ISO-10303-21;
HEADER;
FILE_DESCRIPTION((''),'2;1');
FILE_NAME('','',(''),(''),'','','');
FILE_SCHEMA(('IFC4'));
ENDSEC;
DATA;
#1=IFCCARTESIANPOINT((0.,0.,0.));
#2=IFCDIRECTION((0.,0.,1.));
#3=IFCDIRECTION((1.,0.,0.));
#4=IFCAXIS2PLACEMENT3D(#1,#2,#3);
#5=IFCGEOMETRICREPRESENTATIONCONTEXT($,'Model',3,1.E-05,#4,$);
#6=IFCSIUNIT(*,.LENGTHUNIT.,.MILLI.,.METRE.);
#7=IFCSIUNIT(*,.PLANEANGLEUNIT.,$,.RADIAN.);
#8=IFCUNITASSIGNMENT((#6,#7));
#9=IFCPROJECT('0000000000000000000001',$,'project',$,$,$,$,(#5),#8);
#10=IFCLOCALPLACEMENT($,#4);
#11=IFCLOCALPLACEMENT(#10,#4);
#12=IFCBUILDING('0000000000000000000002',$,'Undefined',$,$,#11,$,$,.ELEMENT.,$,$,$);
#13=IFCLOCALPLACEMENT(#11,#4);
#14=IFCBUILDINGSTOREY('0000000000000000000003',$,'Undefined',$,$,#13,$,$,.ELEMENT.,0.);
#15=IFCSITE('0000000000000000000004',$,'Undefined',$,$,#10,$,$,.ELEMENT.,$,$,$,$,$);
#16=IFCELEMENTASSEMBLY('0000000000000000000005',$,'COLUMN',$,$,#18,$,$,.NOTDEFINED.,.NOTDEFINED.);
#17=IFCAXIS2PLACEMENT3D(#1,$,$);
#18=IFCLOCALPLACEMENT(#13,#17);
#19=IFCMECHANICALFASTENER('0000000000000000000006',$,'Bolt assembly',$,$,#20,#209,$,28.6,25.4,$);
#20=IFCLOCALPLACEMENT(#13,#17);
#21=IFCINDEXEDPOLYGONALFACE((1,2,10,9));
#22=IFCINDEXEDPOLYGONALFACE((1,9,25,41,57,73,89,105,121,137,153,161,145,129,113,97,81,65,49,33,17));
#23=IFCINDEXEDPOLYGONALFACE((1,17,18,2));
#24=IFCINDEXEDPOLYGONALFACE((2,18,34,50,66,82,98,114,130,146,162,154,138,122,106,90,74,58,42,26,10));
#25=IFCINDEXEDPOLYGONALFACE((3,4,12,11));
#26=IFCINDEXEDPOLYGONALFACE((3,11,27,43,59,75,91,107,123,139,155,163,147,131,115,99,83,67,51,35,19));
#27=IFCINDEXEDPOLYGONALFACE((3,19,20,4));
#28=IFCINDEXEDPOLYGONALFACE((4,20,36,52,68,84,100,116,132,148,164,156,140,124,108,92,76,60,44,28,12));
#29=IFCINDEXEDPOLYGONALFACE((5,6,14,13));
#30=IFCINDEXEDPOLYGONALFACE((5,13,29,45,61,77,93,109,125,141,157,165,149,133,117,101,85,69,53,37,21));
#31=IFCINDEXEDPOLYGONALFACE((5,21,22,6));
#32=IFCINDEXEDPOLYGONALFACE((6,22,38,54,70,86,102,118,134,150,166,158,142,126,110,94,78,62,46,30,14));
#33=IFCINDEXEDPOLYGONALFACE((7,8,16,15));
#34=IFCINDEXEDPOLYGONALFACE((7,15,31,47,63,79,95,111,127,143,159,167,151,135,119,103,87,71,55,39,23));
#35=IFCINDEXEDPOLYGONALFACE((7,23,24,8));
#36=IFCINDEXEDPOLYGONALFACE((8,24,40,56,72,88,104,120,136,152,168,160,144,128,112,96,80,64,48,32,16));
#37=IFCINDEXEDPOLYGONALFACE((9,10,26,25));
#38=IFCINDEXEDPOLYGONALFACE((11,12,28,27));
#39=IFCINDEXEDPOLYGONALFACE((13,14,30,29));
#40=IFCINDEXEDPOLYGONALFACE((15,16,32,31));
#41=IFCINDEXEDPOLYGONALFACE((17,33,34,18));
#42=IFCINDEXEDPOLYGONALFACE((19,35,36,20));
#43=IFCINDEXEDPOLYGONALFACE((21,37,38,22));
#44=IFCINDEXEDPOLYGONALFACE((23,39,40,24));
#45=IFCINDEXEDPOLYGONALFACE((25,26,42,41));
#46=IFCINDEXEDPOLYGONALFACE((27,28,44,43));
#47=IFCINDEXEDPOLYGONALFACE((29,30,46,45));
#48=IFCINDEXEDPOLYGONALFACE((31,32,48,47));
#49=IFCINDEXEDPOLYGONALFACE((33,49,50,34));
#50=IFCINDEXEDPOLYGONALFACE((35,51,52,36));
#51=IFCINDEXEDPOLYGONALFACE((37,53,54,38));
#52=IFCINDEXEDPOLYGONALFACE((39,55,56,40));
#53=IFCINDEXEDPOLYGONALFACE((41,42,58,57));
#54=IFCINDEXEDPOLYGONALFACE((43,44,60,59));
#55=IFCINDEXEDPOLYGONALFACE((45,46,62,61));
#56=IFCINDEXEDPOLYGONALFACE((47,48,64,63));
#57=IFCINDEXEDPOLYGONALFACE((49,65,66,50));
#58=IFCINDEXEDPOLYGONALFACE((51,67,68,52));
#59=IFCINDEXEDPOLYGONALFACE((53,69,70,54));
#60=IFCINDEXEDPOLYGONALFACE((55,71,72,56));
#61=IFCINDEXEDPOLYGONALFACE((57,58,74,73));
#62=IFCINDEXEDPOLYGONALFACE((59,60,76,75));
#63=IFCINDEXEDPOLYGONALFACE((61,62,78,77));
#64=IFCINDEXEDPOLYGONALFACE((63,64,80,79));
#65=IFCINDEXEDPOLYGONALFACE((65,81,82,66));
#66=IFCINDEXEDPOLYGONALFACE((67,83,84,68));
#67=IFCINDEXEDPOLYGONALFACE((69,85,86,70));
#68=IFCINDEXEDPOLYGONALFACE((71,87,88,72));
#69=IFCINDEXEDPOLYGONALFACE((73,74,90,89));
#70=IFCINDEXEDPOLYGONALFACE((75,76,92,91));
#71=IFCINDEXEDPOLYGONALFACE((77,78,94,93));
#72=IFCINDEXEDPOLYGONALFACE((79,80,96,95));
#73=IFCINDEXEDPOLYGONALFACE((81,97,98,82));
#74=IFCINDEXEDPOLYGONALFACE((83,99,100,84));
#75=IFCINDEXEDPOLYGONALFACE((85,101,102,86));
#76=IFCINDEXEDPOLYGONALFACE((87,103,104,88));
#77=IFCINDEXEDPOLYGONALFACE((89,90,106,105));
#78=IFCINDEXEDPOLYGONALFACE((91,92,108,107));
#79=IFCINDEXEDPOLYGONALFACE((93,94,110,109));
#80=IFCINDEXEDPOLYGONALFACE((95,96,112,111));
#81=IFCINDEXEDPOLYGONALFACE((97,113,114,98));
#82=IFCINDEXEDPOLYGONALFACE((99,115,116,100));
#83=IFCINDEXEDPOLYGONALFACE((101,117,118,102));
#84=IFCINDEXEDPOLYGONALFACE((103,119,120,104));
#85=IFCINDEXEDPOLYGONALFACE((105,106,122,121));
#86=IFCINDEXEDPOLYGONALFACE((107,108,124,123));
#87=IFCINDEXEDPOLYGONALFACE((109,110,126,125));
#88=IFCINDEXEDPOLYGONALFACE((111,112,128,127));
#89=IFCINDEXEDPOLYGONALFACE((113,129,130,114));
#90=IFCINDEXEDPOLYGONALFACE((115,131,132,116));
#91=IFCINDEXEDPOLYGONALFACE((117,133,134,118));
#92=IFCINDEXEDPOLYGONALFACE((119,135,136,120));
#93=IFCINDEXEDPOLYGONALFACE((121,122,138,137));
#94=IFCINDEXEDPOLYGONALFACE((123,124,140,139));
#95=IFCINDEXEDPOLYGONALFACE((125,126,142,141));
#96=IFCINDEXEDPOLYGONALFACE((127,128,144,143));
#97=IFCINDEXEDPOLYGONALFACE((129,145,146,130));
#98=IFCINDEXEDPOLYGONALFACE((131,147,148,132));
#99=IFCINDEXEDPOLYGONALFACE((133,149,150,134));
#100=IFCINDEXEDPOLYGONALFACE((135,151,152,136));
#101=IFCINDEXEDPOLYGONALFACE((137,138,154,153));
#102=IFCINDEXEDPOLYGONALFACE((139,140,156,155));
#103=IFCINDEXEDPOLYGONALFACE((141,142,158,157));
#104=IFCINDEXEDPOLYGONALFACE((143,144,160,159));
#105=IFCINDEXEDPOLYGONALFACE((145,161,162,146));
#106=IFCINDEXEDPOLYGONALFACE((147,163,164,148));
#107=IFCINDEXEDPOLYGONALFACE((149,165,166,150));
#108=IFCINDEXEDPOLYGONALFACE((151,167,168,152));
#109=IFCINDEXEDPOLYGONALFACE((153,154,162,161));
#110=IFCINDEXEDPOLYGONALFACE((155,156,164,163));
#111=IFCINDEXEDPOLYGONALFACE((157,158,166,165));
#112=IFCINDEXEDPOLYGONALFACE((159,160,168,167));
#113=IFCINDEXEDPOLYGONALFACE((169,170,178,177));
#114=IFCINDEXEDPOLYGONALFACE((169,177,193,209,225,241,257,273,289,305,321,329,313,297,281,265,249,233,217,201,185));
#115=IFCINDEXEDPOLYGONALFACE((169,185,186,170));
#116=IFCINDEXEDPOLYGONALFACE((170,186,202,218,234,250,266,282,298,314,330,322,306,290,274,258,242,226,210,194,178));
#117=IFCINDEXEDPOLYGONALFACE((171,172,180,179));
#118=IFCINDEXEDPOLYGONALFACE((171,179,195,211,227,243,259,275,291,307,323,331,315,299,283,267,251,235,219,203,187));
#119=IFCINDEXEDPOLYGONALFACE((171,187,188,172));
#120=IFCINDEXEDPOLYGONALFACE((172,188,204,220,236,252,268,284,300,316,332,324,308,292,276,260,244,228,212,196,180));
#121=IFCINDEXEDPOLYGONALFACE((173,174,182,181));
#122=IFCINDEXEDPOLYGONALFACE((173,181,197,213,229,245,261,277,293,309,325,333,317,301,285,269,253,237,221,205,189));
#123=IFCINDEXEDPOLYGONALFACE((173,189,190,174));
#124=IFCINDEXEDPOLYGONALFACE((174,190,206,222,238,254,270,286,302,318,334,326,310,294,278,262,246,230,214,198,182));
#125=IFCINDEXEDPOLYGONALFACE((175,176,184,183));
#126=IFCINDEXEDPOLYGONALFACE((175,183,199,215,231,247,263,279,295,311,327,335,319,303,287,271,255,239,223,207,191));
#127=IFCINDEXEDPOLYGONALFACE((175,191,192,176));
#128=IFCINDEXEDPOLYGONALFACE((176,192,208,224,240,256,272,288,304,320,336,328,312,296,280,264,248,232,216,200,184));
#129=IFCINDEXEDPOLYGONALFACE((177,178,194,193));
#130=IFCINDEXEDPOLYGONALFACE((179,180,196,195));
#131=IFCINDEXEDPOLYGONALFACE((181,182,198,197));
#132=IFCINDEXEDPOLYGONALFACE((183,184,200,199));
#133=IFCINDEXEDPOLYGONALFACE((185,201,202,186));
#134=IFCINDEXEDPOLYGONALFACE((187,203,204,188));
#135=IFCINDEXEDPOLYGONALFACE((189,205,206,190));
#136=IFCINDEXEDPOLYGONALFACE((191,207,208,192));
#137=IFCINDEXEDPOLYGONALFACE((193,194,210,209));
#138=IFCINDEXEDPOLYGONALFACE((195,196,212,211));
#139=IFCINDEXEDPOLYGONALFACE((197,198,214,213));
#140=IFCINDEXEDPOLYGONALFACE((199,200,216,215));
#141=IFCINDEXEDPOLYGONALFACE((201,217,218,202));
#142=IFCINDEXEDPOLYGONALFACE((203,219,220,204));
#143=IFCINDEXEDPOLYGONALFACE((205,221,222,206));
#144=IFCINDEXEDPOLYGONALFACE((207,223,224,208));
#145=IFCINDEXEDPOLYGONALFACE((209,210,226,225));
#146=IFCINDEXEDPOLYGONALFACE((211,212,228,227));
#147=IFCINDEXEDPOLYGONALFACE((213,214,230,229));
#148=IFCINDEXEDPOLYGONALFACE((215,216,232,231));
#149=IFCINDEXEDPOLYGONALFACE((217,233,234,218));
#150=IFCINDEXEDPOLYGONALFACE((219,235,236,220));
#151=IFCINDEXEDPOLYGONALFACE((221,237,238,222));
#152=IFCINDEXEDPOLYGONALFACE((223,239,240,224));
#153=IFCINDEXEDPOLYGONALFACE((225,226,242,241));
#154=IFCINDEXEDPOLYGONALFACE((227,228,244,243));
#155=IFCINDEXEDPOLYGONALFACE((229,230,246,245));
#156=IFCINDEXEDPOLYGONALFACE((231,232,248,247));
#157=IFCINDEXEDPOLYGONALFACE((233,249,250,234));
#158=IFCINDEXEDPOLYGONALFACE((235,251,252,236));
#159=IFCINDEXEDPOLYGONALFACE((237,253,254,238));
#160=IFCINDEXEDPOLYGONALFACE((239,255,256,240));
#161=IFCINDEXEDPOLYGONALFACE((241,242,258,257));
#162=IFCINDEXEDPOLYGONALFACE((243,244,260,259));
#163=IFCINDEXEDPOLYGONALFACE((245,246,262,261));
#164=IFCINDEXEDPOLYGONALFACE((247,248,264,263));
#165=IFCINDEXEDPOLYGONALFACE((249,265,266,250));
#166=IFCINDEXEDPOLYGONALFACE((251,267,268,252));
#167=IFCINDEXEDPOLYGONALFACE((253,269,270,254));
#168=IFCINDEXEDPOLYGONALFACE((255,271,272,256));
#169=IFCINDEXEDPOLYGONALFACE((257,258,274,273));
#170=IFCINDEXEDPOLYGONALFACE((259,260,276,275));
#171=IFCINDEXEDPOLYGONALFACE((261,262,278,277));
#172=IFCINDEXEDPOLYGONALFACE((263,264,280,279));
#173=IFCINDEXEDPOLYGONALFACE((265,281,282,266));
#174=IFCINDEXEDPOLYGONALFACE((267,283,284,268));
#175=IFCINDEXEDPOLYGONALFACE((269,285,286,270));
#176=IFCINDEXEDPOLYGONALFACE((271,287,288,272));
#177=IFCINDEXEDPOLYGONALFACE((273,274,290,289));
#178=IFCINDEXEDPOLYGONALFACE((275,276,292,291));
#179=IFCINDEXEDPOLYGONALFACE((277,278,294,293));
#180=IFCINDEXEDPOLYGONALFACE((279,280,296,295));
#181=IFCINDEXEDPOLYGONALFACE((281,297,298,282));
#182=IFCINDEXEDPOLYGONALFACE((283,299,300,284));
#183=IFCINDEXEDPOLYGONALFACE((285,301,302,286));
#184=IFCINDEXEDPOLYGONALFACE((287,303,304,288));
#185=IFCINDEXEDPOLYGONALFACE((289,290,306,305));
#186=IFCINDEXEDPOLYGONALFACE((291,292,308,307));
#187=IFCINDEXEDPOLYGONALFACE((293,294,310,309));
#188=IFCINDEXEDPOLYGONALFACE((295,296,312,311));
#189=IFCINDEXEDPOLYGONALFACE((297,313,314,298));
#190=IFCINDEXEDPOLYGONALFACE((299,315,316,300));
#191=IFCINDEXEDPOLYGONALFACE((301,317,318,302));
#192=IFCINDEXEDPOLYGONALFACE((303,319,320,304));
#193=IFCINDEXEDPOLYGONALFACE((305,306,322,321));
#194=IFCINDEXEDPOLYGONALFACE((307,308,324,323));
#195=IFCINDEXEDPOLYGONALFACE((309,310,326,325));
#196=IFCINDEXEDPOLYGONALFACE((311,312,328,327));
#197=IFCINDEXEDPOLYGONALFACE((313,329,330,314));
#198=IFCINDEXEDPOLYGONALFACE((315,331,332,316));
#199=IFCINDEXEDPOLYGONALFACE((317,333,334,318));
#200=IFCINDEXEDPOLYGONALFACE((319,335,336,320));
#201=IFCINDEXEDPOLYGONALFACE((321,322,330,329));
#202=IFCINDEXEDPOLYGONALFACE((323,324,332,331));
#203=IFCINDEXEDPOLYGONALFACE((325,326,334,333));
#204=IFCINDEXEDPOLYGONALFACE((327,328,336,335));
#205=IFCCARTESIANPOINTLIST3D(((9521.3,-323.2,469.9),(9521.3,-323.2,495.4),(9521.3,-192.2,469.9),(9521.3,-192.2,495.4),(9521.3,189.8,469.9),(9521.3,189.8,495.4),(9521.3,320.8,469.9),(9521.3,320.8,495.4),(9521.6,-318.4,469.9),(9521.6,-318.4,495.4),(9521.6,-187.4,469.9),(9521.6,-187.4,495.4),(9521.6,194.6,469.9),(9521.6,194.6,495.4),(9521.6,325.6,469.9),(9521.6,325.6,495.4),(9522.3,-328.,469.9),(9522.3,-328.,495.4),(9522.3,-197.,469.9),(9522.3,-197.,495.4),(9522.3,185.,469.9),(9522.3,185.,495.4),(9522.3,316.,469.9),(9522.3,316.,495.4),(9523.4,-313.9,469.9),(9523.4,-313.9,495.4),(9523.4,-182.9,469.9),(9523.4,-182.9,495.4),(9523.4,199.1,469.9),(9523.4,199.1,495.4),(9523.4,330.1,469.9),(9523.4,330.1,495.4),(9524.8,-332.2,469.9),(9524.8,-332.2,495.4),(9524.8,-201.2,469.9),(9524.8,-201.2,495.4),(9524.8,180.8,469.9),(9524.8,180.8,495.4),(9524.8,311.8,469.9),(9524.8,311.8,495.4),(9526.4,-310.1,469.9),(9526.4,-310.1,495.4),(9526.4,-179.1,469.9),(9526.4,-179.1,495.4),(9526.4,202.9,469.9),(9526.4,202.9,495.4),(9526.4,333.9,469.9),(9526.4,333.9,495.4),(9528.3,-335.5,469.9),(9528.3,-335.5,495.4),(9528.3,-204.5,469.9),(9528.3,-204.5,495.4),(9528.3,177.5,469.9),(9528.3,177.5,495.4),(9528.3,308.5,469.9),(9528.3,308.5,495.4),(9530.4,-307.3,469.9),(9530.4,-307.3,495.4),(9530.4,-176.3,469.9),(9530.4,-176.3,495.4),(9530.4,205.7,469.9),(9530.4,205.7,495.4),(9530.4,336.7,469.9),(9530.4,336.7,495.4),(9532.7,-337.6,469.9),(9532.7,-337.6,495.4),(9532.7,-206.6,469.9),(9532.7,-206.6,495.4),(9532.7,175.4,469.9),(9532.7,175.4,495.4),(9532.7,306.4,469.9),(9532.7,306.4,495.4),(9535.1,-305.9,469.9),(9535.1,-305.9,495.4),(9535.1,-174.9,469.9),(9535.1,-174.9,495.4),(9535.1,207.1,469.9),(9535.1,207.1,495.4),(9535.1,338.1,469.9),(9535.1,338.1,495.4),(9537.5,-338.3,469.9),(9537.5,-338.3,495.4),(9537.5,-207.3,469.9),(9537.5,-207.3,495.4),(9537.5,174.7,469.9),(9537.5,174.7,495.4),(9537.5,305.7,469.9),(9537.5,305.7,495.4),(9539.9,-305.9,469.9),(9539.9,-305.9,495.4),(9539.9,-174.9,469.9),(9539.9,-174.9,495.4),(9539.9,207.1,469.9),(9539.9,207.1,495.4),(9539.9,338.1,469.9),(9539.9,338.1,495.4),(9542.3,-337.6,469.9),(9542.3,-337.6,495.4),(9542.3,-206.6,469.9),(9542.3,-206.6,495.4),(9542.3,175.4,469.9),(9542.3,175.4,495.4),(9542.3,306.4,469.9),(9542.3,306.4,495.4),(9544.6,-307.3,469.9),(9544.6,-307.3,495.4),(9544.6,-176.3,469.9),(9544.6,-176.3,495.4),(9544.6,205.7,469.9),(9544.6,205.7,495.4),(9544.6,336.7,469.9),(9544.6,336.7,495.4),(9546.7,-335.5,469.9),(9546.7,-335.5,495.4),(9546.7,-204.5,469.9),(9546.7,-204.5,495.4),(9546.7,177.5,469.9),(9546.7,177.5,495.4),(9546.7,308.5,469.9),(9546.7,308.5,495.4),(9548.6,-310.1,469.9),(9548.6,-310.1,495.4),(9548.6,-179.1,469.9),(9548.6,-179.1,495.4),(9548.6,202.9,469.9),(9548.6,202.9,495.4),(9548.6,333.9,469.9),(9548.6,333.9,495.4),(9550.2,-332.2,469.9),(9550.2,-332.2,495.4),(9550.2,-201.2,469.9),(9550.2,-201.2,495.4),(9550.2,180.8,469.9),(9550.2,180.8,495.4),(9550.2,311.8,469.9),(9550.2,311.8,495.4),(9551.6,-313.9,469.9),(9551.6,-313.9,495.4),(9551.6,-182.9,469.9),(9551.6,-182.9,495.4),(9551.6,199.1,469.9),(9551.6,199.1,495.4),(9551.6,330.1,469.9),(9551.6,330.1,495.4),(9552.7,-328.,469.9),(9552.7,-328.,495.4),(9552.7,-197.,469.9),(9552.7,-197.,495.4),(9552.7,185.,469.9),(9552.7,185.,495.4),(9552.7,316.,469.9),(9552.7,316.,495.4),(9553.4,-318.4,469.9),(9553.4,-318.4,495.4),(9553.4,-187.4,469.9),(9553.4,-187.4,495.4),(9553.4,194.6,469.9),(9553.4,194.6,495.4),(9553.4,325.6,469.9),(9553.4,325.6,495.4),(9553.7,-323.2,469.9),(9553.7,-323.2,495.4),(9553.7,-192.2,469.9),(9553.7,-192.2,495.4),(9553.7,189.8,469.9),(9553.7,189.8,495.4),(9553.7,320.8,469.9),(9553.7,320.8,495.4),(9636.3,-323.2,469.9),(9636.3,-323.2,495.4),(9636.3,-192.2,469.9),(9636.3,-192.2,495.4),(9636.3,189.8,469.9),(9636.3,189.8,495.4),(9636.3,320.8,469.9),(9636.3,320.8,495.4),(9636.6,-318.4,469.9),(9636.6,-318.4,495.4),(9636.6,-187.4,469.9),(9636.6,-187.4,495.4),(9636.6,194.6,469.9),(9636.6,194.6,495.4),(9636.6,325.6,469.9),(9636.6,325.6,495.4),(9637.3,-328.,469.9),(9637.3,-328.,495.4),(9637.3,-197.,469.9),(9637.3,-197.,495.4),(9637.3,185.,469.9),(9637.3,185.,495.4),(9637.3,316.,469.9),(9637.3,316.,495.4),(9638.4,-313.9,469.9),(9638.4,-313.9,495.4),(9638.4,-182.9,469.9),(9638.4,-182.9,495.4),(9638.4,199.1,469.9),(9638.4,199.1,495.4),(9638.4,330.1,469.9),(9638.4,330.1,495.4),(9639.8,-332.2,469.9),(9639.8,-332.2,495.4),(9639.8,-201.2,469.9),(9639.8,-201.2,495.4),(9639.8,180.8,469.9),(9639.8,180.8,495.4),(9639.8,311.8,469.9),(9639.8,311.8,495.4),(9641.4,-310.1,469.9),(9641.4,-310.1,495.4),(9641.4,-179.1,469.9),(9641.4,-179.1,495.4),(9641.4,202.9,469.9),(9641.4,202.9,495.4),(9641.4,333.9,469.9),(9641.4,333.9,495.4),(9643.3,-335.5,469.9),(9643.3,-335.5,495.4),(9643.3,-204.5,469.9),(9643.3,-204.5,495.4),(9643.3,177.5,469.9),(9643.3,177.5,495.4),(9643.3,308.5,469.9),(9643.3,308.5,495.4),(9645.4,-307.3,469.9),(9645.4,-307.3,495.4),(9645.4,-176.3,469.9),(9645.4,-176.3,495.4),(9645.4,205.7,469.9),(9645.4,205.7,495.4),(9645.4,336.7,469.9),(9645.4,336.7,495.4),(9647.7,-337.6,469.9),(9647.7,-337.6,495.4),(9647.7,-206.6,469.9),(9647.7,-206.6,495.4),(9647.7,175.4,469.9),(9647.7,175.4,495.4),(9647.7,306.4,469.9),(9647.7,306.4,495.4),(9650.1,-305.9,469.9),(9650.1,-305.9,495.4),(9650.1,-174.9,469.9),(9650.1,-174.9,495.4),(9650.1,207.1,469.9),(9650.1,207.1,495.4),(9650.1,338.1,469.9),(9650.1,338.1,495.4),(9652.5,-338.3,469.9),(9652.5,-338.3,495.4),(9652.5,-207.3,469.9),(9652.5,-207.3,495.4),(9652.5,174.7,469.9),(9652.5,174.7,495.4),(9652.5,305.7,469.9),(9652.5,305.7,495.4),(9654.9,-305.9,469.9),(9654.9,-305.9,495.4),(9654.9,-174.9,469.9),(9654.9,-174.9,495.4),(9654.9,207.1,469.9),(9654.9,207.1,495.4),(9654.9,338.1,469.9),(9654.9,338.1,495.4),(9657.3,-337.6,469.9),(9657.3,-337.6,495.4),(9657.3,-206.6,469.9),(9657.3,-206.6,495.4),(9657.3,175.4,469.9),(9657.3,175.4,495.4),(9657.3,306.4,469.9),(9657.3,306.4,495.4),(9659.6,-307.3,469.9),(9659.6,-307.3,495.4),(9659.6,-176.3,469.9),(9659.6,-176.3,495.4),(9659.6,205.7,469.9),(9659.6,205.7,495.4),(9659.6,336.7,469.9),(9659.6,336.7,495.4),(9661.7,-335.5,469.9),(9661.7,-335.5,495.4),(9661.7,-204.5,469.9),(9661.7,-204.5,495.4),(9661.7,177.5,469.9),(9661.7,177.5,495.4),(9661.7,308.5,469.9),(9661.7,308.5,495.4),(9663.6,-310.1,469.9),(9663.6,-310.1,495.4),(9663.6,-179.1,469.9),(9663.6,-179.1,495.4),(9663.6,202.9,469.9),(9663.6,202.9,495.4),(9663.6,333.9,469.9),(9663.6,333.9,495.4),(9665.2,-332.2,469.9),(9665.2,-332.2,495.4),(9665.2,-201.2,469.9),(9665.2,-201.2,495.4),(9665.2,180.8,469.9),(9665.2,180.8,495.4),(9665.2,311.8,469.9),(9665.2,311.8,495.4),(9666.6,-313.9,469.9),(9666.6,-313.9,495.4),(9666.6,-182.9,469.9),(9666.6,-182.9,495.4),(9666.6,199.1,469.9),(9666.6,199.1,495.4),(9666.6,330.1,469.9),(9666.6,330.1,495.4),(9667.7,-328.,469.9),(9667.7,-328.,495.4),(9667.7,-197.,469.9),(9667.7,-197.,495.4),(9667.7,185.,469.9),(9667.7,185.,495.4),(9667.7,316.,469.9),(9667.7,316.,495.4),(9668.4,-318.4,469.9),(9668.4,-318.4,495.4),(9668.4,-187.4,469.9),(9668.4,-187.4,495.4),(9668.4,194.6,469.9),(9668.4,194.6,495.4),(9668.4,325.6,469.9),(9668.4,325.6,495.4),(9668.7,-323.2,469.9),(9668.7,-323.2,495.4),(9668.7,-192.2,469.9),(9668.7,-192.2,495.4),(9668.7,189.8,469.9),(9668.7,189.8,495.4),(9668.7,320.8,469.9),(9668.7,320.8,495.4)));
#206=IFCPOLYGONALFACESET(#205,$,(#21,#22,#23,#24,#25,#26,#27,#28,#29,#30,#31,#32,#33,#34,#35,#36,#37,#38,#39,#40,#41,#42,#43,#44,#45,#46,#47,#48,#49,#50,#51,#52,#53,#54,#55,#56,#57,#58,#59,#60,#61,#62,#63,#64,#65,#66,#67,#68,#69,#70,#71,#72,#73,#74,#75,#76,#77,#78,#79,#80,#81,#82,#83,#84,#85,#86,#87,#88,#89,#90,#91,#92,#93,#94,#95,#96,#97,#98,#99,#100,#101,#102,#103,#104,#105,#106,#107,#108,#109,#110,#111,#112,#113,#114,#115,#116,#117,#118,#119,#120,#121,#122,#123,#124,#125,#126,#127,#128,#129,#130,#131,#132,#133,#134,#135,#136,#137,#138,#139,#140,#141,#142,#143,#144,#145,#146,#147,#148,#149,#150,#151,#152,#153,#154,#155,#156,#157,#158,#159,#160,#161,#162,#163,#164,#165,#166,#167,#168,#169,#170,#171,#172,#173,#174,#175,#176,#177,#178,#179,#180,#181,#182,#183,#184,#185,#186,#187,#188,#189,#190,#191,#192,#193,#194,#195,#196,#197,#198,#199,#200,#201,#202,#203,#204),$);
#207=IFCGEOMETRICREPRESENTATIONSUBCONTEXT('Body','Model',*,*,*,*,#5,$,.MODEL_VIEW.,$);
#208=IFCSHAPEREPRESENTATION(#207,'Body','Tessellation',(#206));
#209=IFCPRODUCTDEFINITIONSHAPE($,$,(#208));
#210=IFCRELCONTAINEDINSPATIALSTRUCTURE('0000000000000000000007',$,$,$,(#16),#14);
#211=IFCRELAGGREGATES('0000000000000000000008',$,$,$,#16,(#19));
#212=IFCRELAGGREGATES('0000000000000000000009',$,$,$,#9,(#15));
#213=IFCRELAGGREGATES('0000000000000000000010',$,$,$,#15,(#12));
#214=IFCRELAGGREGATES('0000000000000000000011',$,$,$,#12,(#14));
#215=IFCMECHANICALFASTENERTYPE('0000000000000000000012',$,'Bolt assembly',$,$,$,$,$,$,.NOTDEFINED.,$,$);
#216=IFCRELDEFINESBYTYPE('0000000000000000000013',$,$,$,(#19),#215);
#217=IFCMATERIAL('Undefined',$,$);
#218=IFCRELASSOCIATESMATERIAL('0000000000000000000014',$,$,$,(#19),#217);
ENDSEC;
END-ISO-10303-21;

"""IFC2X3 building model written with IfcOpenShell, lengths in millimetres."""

from ifc_helpers import new_model, si_unit, frame, origin_with_axes, origin_2d_with_axis, place, context, subcontext, project, spatial, circle, extrude, source, transform, mapped, material, type_object, element, aggregate, save


model = new_model("IFC2X3")

# Units and contexts
model_context = context("Model", 3, precision=1e-05, world=origin_with_axes())
body_context = subcontext(model_context, "Body", "Model", "MODEL_VIEW")
ifc_project = project(units=[si_unit("LENGTHUNIT", "METRE", prefix="MILLI"), si_unit("PLANEANGLEUNIT", "RADIAN")], contexts=[model_context])

# Site, building, storey
site_placement = place(None, origin_with_axes())
site = spatial("IfcSite", under=ifc_project, at=site_placement, Name="Undefined", CompositionType="ELEMENT")
building_placement = place(site_placement, origin_with_axes())
building = spatial("IfcBuilding", under=site, at=building_placement, Name="Undefined", CompositionType="ELEMENT")
storey_placement = place(building_placement, origin_with_axes())
storey = spatial("IfcBuildingStorey", under=building, at=storey_placement, Name="Undefined", CompositionType="ELEMENT", Elevation=0.0)

# Element assembly
assembly_1_placement = place(storey_placement, origin_with_axes())
assembly_1 = element("IfcElementAssembly", 1, at=assembly_1_placement, inside=storey, Name="COLUMN", AssemblyPlace="NOTDEFINED", PredefinedType="NOTDEFINED")

# Mechanical fastener
ifc_material_1 = material(Name="Undefined")
mechanical_fastener_type = type_object("IfcMechanicalFastenerType", Name="Bolt assembly")
shared_shape_1 = source(origin_with_axes(), body_context, "Body", "SweptSolid", [
    extrude(circle(Radius=16.3, at=origin_2d_with_axis()), frame((0.0, 0.0, 0.0), z_axis=(0.0, 1.0, 0.0), x_axis=(1.0, 0.0, 0.0)), (0.0, 0.0, 1.0), 25.5),
])
mechanical_fastener_1_placement = place(assembly_1_placement, frame((9595.0, 261.9, 495.4), z_axis=(1.0, 0.0, 0.0), x_axis=(0.0, -1.0, 0.0)))
mechanical_fastener_1 = element("IfcMechanicalFastener", 2, at=mechanical_fastener_1_placement, type_object=mechanical_fastener_type, material=ifc_material_1, Name="Bolt assembly", NominalDiameter=28.6, NominalLength=25.4, context=body_context, shape_type="MappedRepresentation", body=[
    mapped(shared_shape_1, transform((-60.1, 0.0, -57.5))),
    mapped(shared_shape_1, transform((-60.1, 0.0, 57.5))),
    mapped(shared_shape_1, transform((70.9, 0.0, -57.5))),
    mapped(shared_shape_1, transform((70.9, 0.0, 57.5))),
    mapped(shared_shape_1, transform((452.9, 0.0, -57.5))),
    mapped(shared_shape_1, transform((452.9, 0.0, 57.5))),
    mapped(shared_shape_1, transform((583.9, 0.0, -57.5))),
    mapped(shared_shape_1, transform((583.9, 0.0, 57.5))),
])
aggregate(assembly_1, [mechanical_fastener_1])

save(model, "model.ifc")
